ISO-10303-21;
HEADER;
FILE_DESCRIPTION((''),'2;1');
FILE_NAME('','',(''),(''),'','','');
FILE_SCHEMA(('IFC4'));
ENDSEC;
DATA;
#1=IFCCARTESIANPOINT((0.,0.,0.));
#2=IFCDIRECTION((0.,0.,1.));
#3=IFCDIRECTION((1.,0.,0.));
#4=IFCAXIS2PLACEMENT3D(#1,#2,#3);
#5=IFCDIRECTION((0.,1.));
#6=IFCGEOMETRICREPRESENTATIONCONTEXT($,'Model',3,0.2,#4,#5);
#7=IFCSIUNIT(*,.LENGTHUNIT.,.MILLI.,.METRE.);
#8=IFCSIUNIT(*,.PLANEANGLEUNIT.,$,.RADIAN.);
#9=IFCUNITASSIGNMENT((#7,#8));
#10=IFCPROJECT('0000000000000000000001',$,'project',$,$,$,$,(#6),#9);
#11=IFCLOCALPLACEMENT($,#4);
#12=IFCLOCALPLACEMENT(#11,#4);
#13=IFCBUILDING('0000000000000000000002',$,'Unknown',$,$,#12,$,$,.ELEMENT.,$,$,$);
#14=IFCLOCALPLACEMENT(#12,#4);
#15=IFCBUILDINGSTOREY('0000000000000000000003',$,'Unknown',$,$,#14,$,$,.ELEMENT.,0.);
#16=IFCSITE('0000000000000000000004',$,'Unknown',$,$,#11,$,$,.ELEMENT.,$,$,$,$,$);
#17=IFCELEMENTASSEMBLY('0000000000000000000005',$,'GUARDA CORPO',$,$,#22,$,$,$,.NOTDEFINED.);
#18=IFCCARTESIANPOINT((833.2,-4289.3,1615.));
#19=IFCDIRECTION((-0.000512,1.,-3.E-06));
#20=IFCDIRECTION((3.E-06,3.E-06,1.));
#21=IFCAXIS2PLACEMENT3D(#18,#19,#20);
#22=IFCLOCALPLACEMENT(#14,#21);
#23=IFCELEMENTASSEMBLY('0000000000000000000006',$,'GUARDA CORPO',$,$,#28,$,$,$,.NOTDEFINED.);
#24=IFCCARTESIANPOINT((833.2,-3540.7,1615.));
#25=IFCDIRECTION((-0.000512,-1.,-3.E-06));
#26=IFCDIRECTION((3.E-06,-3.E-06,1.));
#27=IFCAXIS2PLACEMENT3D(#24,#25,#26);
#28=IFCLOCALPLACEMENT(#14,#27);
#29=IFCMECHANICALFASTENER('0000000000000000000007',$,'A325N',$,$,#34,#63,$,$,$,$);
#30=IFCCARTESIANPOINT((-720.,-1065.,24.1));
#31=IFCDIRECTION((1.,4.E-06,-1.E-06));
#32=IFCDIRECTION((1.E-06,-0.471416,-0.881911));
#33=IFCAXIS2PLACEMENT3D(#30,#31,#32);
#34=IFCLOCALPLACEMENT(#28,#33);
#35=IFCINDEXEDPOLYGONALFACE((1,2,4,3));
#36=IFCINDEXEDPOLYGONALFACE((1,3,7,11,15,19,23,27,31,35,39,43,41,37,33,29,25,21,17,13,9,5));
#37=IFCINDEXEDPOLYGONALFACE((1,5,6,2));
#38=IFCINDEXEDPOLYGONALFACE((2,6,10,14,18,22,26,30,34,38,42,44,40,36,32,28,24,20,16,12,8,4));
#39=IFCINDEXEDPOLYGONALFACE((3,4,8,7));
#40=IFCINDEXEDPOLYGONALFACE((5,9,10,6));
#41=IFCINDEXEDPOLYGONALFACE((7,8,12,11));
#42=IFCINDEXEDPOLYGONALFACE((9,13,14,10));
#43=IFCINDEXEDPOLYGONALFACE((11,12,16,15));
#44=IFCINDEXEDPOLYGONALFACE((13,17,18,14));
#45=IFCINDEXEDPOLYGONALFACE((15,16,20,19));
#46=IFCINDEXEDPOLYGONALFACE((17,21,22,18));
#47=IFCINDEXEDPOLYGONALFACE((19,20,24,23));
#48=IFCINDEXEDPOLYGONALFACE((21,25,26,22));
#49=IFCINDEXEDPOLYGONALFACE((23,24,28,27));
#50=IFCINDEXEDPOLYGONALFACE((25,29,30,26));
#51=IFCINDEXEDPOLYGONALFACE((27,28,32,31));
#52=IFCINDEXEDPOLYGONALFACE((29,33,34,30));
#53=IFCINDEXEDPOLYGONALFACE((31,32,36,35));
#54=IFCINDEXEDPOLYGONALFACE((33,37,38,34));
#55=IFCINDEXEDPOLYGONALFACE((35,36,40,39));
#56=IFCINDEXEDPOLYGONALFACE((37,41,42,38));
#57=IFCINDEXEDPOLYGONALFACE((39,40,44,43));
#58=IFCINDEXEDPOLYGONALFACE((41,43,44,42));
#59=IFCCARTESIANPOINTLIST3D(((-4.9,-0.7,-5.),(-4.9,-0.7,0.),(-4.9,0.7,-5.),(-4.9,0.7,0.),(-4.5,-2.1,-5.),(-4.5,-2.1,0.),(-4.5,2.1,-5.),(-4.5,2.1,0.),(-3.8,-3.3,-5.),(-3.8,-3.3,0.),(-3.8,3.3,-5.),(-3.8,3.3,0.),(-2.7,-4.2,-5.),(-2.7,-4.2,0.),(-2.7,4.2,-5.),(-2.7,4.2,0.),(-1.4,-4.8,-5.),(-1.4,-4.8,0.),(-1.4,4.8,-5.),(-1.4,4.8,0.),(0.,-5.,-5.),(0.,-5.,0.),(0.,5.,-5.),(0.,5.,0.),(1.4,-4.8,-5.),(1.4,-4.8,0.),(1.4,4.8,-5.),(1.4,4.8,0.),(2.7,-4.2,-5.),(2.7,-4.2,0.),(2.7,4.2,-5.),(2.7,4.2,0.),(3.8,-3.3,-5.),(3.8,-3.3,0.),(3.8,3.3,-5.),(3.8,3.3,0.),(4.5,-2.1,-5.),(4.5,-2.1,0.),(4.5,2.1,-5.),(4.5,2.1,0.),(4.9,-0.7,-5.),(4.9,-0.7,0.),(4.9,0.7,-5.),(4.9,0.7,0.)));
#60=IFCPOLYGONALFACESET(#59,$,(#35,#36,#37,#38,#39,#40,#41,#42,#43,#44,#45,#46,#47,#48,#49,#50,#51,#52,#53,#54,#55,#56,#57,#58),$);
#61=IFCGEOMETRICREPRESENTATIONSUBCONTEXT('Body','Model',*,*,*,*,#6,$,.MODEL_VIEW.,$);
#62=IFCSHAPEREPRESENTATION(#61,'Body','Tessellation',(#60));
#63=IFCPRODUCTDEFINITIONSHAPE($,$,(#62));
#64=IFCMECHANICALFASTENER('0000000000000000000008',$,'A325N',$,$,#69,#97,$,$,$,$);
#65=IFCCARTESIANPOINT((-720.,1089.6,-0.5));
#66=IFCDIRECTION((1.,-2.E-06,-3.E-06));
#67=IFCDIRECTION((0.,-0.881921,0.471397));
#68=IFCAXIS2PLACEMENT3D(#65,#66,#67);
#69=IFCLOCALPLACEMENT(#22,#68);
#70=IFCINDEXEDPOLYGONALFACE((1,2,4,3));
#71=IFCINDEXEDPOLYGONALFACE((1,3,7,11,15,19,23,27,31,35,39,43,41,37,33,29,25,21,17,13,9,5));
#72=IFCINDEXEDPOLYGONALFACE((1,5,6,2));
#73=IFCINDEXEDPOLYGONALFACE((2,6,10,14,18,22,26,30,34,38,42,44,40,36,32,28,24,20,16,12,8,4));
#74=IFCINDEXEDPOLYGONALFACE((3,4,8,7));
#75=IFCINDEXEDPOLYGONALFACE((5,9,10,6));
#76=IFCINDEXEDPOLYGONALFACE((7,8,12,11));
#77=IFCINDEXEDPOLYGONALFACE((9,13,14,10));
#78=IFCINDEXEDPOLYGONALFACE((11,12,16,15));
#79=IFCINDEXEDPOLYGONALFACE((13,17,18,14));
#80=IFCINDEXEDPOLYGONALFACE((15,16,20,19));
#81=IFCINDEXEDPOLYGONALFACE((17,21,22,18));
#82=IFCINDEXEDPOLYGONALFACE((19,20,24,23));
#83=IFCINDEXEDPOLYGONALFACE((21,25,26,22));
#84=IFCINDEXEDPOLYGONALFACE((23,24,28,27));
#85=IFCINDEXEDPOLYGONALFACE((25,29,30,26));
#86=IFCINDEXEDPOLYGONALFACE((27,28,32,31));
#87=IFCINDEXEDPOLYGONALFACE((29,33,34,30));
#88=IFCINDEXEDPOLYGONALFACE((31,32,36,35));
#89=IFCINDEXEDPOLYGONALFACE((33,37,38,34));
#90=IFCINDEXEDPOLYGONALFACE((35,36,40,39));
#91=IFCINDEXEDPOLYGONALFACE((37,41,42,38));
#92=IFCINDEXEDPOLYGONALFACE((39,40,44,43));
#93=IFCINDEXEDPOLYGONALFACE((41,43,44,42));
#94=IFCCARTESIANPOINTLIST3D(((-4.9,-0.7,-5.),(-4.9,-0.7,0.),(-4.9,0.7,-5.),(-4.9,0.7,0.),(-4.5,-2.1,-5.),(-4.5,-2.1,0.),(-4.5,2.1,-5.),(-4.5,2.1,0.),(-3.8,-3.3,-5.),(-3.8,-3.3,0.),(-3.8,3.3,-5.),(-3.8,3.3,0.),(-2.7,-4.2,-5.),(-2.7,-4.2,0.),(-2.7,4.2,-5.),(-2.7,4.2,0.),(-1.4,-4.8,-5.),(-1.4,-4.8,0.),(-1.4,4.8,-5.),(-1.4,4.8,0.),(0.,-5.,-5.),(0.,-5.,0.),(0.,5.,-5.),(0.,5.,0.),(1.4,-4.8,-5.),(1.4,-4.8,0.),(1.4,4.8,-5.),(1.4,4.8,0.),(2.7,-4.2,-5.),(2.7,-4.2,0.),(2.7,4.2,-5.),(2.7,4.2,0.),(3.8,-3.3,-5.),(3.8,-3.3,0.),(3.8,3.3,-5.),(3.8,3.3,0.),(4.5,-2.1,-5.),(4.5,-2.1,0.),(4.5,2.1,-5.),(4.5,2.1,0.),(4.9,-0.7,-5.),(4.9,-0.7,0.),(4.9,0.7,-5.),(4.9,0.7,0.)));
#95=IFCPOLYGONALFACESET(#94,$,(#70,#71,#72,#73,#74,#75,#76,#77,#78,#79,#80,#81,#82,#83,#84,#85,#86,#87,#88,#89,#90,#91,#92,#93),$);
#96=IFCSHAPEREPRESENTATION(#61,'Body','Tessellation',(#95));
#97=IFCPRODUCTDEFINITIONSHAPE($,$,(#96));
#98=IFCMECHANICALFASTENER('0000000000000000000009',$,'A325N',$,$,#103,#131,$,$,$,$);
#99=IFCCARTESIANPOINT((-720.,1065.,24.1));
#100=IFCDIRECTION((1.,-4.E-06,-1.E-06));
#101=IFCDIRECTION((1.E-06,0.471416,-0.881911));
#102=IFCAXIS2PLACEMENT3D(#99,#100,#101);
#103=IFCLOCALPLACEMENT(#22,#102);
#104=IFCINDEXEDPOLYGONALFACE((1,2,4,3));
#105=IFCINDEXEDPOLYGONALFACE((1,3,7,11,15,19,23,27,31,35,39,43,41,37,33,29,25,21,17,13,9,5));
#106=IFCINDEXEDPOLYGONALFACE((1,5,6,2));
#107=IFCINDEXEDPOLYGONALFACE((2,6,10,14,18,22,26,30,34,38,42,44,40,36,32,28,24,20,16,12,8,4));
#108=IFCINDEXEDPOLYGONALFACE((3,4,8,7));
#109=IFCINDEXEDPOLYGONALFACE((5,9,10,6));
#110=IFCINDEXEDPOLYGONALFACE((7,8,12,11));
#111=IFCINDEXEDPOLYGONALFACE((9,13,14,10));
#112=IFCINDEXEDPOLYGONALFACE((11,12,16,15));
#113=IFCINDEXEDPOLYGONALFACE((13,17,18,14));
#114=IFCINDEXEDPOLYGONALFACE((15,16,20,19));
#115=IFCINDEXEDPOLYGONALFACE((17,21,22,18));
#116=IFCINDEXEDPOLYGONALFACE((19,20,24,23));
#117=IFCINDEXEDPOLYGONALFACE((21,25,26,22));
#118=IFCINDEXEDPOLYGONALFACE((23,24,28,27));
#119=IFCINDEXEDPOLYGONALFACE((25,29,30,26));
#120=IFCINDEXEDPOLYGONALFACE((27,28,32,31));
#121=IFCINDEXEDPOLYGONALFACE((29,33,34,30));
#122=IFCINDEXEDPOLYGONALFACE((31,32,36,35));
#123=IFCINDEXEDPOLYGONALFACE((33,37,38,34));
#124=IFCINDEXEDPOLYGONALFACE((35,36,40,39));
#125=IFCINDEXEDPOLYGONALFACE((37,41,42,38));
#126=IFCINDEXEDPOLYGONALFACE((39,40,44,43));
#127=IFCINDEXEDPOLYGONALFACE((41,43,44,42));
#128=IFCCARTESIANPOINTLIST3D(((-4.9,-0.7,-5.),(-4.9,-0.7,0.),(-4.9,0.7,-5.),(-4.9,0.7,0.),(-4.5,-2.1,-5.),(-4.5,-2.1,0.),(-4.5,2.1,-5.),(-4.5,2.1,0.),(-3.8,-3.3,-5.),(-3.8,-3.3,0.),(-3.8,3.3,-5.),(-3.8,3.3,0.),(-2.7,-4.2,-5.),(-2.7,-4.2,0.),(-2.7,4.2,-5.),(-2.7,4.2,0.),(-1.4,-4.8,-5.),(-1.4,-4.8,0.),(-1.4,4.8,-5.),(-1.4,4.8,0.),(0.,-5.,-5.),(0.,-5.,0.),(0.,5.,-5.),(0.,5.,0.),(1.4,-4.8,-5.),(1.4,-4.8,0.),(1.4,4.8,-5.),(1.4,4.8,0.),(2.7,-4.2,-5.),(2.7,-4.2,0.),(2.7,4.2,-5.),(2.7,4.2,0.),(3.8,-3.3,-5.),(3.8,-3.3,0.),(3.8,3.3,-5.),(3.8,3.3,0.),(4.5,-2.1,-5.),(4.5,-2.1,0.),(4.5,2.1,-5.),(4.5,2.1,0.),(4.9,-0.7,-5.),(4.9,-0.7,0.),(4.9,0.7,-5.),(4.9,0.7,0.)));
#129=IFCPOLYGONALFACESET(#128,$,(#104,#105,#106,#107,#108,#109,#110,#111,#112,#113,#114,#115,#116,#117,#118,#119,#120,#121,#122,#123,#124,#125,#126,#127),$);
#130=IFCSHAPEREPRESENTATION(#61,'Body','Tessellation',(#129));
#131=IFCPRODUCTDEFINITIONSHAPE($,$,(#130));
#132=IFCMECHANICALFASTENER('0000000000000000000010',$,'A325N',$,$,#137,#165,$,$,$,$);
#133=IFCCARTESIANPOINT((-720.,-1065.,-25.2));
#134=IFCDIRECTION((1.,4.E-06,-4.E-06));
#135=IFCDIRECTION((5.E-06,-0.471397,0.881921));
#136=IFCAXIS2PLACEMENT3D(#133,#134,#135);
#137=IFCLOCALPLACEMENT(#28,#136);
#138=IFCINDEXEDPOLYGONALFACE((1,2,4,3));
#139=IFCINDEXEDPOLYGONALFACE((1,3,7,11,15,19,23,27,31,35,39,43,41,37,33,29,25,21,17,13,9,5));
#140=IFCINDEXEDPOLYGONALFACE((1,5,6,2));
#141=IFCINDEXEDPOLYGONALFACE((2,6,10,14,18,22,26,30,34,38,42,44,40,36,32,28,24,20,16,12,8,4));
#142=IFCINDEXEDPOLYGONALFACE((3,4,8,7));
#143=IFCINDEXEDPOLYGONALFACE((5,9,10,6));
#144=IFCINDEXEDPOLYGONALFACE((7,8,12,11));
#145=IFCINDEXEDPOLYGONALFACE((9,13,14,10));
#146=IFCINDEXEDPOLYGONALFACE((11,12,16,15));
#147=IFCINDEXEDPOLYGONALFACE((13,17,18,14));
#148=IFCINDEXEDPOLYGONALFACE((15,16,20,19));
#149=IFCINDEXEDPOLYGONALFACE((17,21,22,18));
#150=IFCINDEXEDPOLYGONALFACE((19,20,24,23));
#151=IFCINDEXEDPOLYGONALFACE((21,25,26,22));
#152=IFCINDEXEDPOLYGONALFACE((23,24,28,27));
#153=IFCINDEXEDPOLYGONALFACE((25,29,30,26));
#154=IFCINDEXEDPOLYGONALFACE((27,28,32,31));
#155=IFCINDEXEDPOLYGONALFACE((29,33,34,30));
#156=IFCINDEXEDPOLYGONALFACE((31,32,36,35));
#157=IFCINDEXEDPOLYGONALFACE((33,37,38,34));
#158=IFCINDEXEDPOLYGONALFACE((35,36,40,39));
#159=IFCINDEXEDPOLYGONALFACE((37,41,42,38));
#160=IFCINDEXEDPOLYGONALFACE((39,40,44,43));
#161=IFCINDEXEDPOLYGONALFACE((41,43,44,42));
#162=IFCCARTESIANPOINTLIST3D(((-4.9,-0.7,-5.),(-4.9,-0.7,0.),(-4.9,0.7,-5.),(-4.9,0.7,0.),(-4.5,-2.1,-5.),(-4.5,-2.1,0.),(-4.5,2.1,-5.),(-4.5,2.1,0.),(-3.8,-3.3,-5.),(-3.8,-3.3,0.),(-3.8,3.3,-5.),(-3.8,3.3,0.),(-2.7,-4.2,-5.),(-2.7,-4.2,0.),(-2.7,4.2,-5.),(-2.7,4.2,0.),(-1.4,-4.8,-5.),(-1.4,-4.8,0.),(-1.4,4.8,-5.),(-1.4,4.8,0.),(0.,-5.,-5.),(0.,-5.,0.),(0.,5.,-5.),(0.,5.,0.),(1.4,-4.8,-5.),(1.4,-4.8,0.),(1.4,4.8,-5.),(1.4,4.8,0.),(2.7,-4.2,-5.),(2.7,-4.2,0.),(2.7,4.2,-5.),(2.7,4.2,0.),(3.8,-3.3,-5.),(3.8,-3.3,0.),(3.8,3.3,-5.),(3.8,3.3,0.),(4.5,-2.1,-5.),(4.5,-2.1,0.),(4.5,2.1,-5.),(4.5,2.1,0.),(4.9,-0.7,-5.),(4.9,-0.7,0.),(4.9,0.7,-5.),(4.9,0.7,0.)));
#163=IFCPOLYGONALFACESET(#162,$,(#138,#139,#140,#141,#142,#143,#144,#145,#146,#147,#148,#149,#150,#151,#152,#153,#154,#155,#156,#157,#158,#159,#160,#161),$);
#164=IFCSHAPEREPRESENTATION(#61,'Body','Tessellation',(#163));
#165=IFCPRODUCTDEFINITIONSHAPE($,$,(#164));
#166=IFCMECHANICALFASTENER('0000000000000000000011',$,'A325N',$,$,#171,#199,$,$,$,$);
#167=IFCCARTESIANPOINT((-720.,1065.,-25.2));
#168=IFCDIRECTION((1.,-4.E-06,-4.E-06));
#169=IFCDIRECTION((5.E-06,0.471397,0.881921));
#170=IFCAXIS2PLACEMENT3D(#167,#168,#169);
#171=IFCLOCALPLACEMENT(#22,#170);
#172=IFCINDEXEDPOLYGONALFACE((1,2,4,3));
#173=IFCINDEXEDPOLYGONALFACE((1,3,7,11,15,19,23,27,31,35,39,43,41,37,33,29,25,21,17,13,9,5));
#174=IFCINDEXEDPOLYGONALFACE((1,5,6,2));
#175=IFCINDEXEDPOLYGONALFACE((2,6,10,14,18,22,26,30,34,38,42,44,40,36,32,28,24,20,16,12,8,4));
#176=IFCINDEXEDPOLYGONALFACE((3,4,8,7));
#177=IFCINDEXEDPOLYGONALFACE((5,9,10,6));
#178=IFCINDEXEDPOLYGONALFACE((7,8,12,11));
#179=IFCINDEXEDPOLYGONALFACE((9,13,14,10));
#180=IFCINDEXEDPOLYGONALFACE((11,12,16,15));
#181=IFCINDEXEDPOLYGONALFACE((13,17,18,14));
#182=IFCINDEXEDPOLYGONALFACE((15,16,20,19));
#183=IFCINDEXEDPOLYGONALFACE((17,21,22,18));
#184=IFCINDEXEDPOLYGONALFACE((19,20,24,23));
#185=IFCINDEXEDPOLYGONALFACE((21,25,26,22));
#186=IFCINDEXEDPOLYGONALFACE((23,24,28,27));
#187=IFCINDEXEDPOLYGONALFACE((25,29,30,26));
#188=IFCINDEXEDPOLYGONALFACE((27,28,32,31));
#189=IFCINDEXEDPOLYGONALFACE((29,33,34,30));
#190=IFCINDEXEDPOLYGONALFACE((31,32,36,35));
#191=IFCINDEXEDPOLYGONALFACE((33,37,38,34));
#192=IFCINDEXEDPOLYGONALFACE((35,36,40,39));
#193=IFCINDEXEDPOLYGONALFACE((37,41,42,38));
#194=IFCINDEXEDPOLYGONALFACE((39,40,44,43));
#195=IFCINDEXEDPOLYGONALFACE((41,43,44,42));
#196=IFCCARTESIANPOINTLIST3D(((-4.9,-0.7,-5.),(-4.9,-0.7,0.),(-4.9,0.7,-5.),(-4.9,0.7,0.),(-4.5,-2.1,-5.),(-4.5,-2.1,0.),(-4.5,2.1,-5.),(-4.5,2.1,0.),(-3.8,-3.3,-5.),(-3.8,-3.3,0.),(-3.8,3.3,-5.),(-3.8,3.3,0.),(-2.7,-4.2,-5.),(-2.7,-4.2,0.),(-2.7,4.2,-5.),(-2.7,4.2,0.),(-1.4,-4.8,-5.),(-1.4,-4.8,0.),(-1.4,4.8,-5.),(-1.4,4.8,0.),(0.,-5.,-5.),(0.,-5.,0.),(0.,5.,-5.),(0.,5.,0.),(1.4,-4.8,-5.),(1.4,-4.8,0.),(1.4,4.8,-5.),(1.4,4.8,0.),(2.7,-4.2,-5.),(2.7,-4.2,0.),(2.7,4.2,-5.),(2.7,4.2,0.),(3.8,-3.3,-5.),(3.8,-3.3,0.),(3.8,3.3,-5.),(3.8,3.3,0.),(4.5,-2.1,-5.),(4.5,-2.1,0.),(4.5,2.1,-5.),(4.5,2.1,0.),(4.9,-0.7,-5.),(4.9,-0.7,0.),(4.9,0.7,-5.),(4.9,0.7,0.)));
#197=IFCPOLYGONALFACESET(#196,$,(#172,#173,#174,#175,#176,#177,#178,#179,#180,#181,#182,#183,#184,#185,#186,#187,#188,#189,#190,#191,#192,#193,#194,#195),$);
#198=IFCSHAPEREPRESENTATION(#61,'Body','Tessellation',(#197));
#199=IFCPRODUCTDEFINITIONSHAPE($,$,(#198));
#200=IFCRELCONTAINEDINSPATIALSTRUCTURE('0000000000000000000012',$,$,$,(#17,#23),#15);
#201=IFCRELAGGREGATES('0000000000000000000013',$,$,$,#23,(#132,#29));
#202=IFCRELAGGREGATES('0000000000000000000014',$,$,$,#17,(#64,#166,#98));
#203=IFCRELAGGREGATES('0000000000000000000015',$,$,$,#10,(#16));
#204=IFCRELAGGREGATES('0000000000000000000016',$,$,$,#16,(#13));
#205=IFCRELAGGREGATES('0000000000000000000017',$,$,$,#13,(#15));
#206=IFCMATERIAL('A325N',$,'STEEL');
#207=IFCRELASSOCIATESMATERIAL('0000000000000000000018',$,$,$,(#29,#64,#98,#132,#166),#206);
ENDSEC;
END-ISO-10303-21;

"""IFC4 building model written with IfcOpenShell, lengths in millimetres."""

from ifc_helpers import new_model, si_unit, direction, frame, origin_with_axes, place, context, subcontext, project, spatial, arc, indexed_curve, outline, extrude, source, transform, mapped, material, element, aggregate, save


model = new_model("IFC4")

# Units and contexts
model_context = context("Model", 3, precision=0.2, world=origin_with_axes(), true_north=direction((0.0, 1.0)))
body_context = subcontext(model_context, "Body", "Model", "MODEL_VIEW")
ifc_project = project(units=[si_unit("LENGTHUNIT", "METRE", prefix="MILLI"), si_unit("PLANEANGLEUNIT", "RADIAN")], contexts=[model_context])

# Site, building, storey
site_placement = place(None, origin_with_axes())
site = spatial("IfcSite", under=ifc_project, at=site_placement, Name="Unknown", CompositionType="ELEMENT")
building_placement = place(site_placement, origin_with_axes())
building = spatial("IfcBuilding", under=site, at=building_placement, Name="Unknown", CompositionType="ELEMENT")
storey_placement = place(building_placement, origin_with_axes())
storey = spatial("IfcBuildingStorey", under=building, at=storey_placement, Name="Unknown", CompositionType="ELEMENT", Elevation=0.0)

# Element assembly
assembly_1_placement = place(storey_placement, frame((833.2, -4289.3, 1615.0), z_axis=(-0.000512, 1.0, -0.000003), x_axis=(0.000003, 0.000003, 1.0)))
assembly_1 = element("IfcElementAssembly", 1, at=assembly_1_placement, inside=storey, Name="GUARDA CORPO", PredefinedType="NOTDEFINED")

# Element assembly
assembly_2_placement = place(storey_placement, frame((833.2, -3540.7, 1615.0), z_axis=(-0.000512, -1.0, -0.000003), x_axis=(0.000003, -0.000003, 1.0)))
assembly_2 = element("IfcElementAssembly", 2, at=assembly_2_placement, inside=storey, Name="GUARDA CORPO", PredefinedType="NOTDEFINED")

# Shared definitions
ifc_material_1 = material(Name="A325N", Category="STEEL")

# Mechanical fasteners
shared_shape_1 = source(origin_with_axes(), body_context, "Body", "SweptSolid", [
    extrude(outline(indexed_curve([(5.0, 0.0), (0.0, 5.0), (-5.0, 0.0), (0.0, -5.0)], segments=[arc(1, 2, 3), arc(3, 4, 1)])), frame((0.0, 0.0, 0.0), z_axis=(0.0, 0.0, -1.0), x_axis=(0.0, 1.0, 0.0)), (0.0, 0.0, 1.0), 5.0),
])
mechanical_fastener_1_placement = place(assembly_2_placement, frame((-720.0, -1065.0, 24.1), z_axis=(1.0, 0.000004, -0.000001), x_axis=(0.000001, -0.471416, -0.881911)))
mechanical_fastener_1 = element("IfcMechanicalFastener", 3, at=mechanical_fastener_1_placement, material=ifc_material_1, Name="A325N", context=body_context, shape_type="MappedRepresentation", body=[
    mapped(shared_shape_1, transform((0.0, 0.0, 0.0))),
])
mechanical_fastener_2_placement = place(assembly_1_placement, frame((-720.0, 1089.6, -0.5), z_axis=(1.0, -0.000002, -0.000003), x_axis=(0.0, -0.881921, 0.471397)))
mechanical_fastener_2 = element("IfcMechanicalFastener", 4, at=mechanical_fastener_2_placement, material=ifc_material_1, Name="A325N", context=body_context, shape_type="MappedRepresentation", body=[
    mapped(shared_shape_1, transform((0.0, 0.0, 0.0))),
])
mechanical_fastener_3_placement = place(assembly_1_placement, frame((-720.0, 1065.0, 24.1), z_axis=(1.0, -0.000004, -0.000001), x_axis=(0.000001, 0.471416, -0.881911)))
mechanical_fastener_3 = element("IfcMechanicalFastener", 5, at=mechanical_fastener_3_placement, material=ifc_material_1, Name="A325N", context=body_context, shape_type="MappedRepresentation", body=[
    mapped(shared_shape_1, transform((0.0, 0.0, 0.0))),
])
shared_shape_2 = source(origin_with_axes(), body_context, "Body", "SweptSolid", [
    extrude(outline(indexed_curve([(5.0, 0.0), (0.0, 5.0), (-5.0, 0.0), (0.0, -5.0)], segments=[arc(1, 2, 3), arc(3, 4, 1)])), frame((0.0, 0.0, 0.0), z_axis=(0.0, 0.0, -1.0), x_axis=(0.0, 1.0, 0.0)), (0.0, 0.0, 1.0), 5.0),
])
mechanical_fastener_4_placement = place(assembly_2_placement, frame((-720.0, -1065.0, -25.2), z_axis=(1.0, 0.000004, -0.000004), x_axis=(0.000005, -0.471397, 0.881921)))
mechanical_fastener_4 = element("IfcMechanicalFastener", 6, at=mechanical_fastener_4_placement, material=ifc_material_1, Name="A325N", context=body_context, shape_type="MappedRepresentation", body=[
    mapped(shared_shape_2, transform((0.0, 0.0, 0.0))),
])
aggregate(assembly_2, [mechanical_fastener_4, mechanical_fastener_1])
mechanical_fastener_5_placement = place(assembly_1_placement, frame((-720.0, 1065.0, -25.2), z_axis=(1.0, -0.000004, -0.000004), x_axis=(0.000005, 0.471397, 0.881921)))
mechanical_fastener_5 = element("IfcMechanicalFastener", 7, at=mechanical_fastener_5_placement, material=ifc_material_1, Name="A325N", context=body_context, shape_type="MappedRepresentation", body=[
    mapped(shared_shape_2, transform((0.0, 0.0, 0.0))),
])
aggregate(assembly_1, [mechanical_fastener_2, mechanical_fastener_5, mechanical_fastener_3])

save(model, "model.ifc")
